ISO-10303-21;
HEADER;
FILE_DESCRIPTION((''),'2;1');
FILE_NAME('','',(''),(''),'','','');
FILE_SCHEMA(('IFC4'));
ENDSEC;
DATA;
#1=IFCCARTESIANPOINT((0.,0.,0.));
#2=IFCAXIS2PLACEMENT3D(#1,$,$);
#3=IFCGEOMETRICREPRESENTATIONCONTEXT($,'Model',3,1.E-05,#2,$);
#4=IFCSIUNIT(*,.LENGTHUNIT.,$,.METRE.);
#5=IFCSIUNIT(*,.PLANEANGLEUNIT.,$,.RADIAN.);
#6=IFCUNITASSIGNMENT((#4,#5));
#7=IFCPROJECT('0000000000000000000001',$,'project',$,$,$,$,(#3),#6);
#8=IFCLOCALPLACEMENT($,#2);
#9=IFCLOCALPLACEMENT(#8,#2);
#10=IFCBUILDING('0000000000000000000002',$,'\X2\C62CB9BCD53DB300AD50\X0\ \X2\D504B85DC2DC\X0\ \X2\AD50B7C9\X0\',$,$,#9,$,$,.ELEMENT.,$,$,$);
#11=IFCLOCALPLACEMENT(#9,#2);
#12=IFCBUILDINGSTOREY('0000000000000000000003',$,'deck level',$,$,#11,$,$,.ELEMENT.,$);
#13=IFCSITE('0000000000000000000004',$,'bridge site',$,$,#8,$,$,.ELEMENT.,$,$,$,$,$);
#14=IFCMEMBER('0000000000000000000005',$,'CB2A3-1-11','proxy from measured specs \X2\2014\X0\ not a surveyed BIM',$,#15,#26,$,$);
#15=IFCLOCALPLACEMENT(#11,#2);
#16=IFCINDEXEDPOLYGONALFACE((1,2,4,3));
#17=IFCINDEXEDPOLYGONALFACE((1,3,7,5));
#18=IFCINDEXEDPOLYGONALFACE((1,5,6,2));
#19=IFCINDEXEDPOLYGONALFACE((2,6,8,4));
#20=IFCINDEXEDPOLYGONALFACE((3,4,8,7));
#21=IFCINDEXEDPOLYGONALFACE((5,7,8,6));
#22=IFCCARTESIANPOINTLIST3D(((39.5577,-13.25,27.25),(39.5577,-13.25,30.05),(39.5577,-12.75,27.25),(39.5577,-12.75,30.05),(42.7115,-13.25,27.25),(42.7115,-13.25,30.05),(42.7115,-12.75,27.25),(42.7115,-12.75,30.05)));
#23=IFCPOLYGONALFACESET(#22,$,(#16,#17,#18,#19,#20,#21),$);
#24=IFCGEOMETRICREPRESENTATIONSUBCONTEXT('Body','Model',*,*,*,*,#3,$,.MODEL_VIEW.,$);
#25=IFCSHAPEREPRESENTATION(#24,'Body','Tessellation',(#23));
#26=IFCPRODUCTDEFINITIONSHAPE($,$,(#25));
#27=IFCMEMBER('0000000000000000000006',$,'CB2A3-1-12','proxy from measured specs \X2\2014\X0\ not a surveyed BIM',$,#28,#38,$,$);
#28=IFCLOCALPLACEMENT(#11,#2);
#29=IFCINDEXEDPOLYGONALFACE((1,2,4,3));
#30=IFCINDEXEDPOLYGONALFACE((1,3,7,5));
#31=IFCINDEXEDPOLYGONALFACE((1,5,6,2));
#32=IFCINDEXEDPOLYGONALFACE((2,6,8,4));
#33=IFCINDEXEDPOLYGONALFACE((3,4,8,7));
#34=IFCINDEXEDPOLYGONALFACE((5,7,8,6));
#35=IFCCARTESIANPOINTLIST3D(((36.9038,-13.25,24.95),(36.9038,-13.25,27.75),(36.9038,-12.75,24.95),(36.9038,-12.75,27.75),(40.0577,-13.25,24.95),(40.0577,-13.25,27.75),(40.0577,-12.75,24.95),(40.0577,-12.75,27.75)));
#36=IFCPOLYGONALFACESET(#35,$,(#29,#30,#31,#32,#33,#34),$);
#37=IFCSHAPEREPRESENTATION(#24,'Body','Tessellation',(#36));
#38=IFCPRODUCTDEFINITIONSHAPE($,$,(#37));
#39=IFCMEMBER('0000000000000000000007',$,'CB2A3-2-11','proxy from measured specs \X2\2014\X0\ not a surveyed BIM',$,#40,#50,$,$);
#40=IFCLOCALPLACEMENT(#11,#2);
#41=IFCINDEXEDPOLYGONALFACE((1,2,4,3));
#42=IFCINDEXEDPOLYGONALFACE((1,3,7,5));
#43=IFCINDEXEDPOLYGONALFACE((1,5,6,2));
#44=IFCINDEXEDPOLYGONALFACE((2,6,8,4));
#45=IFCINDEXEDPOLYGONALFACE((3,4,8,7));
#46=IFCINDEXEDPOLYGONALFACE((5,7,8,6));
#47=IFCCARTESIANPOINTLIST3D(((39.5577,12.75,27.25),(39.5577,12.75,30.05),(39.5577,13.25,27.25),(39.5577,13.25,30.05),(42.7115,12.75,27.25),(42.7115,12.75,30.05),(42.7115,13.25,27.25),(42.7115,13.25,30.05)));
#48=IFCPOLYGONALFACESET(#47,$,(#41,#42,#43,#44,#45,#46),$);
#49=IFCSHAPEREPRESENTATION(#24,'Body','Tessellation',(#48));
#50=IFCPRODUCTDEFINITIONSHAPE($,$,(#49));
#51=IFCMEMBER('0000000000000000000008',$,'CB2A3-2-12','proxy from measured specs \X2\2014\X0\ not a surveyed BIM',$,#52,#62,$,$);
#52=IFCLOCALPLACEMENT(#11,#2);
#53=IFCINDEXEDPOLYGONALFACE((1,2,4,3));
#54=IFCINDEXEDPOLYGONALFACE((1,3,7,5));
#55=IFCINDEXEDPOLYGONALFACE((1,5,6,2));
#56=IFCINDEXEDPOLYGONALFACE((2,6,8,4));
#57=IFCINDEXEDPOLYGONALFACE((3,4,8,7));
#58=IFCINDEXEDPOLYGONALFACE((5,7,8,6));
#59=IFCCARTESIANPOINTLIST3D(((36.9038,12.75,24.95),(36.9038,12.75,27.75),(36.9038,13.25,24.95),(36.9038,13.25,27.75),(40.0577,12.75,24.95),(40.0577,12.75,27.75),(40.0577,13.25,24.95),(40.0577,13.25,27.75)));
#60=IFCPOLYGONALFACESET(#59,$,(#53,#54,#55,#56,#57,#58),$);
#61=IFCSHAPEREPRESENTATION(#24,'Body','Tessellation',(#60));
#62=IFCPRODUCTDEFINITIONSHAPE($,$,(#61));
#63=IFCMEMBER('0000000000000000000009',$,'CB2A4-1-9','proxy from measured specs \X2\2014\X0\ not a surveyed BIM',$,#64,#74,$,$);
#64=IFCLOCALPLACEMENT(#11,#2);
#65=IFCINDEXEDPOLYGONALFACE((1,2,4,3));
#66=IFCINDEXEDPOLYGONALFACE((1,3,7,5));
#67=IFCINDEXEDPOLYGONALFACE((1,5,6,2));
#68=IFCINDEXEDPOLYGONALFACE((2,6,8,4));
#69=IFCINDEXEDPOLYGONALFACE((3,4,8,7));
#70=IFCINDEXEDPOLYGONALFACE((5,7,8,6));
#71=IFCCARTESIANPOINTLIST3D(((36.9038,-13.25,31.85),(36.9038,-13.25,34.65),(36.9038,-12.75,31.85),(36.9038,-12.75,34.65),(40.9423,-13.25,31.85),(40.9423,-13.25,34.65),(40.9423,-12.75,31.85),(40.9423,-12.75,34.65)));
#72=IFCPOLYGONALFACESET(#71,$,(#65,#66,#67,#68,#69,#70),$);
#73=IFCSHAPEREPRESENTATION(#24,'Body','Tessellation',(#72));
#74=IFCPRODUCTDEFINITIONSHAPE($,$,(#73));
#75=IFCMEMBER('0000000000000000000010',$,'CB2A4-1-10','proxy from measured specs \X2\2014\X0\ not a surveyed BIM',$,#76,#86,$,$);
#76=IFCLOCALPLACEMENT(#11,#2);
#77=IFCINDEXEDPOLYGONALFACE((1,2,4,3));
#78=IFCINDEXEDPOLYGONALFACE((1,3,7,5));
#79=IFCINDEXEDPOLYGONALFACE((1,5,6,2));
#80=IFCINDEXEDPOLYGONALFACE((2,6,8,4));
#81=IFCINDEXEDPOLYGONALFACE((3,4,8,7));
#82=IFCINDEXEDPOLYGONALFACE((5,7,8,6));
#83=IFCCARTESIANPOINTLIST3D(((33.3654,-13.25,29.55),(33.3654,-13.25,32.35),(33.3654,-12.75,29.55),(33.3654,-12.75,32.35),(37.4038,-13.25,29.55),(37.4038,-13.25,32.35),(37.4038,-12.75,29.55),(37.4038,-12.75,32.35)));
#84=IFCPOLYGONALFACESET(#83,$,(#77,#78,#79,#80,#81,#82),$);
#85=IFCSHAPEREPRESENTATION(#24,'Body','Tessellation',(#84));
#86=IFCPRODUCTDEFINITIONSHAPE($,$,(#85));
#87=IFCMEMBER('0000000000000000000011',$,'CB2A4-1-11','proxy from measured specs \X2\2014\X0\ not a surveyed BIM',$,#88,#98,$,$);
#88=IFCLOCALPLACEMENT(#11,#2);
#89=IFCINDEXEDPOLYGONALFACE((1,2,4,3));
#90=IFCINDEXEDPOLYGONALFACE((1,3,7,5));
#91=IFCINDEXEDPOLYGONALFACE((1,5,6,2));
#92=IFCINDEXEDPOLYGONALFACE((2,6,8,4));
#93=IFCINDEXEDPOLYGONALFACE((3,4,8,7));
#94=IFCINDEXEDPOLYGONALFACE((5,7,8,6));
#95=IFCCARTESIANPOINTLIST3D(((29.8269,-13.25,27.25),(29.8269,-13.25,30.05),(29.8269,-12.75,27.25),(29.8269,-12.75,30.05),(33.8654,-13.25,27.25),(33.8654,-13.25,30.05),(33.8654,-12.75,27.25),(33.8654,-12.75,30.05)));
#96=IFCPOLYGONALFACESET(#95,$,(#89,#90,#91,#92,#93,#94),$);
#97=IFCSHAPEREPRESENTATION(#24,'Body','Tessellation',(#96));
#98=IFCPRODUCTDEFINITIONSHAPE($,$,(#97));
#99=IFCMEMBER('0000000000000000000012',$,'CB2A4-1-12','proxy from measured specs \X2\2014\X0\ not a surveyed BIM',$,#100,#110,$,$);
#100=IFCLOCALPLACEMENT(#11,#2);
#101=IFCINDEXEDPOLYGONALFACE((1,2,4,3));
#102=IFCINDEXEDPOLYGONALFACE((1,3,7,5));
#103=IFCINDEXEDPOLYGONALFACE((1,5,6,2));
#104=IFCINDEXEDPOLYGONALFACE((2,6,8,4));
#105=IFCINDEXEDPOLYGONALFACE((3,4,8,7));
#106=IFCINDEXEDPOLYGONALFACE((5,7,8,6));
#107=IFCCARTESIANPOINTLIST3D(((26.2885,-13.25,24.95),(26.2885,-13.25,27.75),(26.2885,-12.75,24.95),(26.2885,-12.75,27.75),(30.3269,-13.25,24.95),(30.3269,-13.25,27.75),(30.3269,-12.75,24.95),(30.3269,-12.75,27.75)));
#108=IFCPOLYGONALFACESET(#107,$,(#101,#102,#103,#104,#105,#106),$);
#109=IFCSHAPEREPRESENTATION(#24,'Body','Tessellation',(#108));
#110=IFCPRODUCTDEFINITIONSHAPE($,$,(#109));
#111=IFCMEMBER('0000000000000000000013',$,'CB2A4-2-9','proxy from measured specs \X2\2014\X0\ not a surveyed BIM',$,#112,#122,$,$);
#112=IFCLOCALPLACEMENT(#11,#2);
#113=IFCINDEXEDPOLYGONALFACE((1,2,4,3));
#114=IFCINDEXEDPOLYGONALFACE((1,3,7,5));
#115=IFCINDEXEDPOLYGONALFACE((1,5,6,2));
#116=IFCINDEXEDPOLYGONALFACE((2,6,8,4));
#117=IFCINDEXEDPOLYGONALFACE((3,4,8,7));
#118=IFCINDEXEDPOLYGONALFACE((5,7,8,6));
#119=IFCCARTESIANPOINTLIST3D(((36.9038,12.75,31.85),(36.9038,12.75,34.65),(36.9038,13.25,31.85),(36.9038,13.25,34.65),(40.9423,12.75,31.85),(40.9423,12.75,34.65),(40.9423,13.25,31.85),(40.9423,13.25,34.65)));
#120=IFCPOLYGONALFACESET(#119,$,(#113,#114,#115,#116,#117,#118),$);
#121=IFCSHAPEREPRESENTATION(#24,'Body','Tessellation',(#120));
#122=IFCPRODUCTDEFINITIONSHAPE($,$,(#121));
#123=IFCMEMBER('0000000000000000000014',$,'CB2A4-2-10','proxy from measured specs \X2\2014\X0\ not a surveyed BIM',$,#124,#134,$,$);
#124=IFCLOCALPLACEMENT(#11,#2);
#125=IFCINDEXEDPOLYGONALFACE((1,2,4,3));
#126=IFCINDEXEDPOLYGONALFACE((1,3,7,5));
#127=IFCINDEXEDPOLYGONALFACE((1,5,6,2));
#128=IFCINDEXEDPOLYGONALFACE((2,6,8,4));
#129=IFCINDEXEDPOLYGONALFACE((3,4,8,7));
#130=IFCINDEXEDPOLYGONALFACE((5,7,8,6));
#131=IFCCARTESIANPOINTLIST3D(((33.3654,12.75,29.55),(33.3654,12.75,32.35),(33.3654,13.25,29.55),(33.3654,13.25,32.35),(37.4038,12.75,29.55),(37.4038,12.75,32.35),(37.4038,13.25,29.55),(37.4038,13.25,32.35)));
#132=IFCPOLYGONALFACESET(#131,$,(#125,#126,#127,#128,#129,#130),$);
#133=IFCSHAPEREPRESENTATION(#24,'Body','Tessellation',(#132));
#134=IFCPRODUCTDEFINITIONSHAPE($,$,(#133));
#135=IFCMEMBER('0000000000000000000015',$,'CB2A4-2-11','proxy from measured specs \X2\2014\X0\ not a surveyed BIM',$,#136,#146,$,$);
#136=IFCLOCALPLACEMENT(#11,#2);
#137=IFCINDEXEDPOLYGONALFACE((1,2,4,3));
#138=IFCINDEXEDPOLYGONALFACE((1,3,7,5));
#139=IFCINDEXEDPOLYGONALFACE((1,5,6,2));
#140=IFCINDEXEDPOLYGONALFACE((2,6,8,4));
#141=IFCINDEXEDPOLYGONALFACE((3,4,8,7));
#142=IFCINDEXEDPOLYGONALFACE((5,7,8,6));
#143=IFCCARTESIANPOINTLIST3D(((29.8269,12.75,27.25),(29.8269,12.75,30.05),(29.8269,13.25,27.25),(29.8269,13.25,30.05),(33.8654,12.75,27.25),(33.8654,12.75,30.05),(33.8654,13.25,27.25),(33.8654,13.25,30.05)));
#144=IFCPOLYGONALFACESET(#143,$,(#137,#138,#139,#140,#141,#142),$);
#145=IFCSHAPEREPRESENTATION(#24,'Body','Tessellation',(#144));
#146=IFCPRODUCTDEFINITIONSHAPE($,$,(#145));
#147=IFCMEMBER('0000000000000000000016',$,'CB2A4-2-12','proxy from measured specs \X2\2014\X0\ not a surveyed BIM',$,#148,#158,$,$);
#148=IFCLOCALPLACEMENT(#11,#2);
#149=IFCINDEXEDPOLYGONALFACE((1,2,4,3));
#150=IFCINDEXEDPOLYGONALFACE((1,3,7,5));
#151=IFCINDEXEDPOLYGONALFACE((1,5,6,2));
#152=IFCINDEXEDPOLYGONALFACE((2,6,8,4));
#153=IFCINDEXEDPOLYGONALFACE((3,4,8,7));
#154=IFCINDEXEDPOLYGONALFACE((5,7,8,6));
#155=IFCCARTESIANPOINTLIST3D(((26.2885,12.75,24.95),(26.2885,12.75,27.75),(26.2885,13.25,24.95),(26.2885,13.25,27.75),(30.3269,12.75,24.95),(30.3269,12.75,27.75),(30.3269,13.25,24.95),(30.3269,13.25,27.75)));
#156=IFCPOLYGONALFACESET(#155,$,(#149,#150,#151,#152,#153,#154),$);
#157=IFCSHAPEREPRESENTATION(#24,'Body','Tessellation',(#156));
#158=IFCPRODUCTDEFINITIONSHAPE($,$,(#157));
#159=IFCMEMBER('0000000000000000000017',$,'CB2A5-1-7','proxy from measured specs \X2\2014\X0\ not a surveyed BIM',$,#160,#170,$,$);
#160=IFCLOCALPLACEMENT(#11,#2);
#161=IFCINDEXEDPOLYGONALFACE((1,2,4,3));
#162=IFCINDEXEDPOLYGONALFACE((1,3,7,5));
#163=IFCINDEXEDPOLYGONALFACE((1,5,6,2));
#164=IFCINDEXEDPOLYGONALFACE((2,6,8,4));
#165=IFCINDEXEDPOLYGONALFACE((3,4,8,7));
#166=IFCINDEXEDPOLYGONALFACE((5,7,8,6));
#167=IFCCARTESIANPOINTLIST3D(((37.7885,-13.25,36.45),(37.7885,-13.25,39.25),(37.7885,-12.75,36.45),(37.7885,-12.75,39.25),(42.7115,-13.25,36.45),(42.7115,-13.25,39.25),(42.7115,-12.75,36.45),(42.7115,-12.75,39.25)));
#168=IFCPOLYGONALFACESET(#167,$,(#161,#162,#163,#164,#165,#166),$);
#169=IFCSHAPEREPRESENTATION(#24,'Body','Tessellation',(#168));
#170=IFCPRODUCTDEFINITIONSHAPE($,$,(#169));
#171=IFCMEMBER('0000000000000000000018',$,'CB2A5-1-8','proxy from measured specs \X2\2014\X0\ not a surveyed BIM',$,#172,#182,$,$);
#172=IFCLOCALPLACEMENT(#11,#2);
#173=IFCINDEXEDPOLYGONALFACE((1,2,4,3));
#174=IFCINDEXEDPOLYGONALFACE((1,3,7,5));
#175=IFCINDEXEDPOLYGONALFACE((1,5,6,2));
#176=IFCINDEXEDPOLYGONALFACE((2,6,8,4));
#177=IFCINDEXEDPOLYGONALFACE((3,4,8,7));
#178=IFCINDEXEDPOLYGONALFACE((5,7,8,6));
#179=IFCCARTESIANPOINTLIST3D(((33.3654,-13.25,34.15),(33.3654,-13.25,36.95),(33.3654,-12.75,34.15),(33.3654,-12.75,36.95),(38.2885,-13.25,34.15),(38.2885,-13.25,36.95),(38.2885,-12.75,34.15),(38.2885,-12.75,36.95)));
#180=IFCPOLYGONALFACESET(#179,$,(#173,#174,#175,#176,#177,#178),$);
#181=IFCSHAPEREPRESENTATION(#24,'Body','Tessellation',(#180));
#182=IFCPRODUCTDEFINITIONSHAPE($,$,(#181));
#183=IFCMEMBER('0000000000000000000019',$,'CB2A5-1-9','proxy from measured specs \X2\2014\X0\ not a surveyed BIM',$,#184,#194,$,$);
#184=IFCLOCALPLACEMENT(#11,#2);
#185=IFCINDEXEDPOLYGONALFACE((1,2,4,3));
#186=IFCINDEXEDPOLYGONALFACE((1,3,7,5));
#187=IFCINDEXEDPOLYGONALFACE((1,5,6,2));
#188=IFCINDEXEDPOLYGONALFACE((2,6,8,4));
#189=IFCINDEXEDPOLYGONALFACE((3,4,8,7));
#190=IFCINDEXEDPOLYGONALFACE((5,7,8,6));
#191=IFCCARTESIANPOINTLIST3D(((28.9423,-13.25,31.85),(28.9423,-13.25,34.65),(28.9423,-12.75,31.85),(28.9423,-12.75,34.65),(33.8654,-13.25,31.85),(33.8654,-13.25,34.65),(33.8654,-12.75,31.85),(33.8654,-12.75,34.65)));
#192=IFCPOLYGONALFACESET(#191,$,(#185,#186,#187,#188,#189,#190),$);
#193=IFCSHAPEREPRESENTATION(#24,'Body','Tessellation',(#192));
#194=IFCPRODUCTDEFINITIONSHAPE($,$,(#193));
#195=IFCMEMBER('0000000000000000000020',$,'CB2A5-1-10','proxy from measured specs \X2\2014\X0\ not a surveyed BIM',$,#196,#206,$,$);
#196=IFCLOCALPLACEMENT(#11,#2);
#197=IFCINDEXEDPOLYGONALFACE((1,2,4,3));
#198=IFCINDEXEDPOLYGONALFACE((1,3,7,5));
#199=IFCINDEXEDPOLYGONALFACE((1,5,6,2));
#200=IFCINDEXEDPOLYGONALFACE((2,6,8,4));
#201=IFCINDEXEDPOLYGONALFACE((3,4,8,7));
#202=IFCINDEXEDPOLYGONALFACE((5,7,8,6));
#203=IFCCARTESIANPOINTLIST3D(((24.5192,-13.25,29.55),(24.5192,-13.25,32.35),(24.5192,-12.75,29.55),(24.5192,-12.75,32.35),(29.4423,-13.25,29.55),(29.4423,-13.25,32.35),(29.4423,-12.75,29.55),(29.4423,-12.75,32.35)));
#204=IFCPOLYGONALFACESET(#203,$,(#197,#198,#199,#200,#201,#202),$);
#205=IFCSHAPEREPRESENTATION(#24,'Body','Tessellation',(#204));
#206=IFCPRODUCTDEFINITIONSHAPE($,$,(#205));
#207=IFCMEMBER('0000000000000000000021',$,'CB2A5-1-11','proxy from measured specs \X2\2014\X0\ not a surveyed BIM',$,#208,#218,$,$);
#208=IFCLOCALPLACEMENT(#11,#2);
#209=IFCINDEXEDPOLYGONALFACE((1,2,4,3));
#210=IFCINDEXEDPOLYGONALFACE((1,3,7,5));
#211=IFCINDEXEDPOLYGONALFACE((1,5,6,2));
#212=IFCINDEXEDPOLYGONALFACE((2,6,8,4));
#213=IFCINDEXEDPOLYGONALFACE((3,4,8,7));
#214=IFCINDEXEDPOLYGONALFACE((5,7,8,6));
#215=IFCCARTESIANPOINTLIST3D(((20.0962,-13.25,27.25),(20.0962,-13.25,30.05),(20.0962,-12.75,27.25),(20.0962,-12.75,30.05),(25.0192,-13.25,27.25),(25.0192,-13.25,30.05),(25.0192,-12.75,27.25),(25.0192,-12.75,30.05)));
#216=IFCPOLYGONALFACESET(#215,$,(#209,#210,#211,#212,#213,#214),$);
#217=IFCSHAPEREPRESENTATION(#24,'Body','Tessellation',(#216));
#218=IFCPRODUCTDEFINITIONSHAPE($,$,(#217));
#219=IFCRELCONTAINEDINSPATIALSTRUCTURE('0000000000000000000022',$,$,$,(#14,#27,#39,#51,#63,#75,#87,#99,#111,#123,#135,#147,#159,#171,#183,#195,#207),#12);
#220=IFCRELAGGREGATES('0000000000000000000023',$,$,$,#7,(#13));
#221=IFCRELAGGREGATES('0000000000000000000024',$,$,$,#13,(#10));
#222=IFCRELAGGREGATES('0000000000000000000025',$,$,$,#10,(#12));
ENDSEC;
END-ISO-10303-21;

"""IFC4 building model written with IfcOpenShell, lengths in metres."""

from ifc_helpers import new_model, si_unit, frame, origin, origin_2d, place, context, subcontext, project, spatial, rectangle, extrude, element, save


model = new_model("IFC4")

# Units and contexts
model_context = context("Model", 3, precision=1e-05, world=origin())
body_context = subcontext(model_context, "Body", "Model", "MODEL_VIEW")
ifc_project = project(units=[si_unit("LENGTHUNIT", "METRE"), si_unit("PLANEANGLEUNIT", "RADIAN")], contexts=[model_context])

# Site, building, storey
site_placement = place(None, origin())
site = spatial("IfcSite", under=ifc_project, at=site_placement, Name="bridge site", CompositionType="ELEMENT")
building_placement = place(site_placement, origin())
building = spatial("IfcBuilding", under=site, at=building_placement, Name="올림픽대교 프록시 교량", CompositionType="ELEMENT")
storey_placement = place(building_placement, origin())
storey = spatial("IfcBuildingStorey", under=building, at=storey_placement, Name="deck level", CompositionType="ELEMENT")

# Members
member_1_placement = place(storey_placement, frame((41.1346, -13.0, 27.25)))
element("IfcMember", 1, at=member_1_placement, inside=storey, Name="CB2A3-1-11", Description="proxy from measured specs — not a surveyed BIM", context=body_context, shape_type="SweptSolid", body=[
    extrude(rectangle(XDim=3.1538, YDim=0.5, at=origin_2d()), origin(), (0.0, 0.0, 1.0), 2.8),
])
member_2_placement = place(storey_placement, frame((38.4808, -13.0, 24.95)))
element("IfcMember", 2, at=member_2_placement, inside=storey, Name="CB2A3-1-12", Description="proxy from measured specs — not a surveyed BIM", context=body_context, shape_type="SweptSolid", body=[
    extrude(rectangle(XDim=3.1538, YDim=0.5, at=origin_2d()), origin(), (0.0, 0.0, 1.0), 2.8),
])
member_3_placement = place(storey_placement, frame((41.1346, 13.0, 27.25)))
element("IfcMember", 3, at=member_3_placement, inside=storey, Name="CB2A3-2-11", Description="proxy from measured specs — not a surveyed BIM", context=body_context, shape_type="SweptSolid", body=[
    extrude(rectangle(XDim=3.1538, YDim=0.5, at=origin_2d()), origin(), (0.0, 0.0, 1.0), 2.8),
])
member_4_placement = place(storey_placement, frame((38.4808, 13.0, 24.95)))
element("IfcMember", 4, at=member_4_placement, inside=storey, Name="CB2A3-2-12", Description="proxy from measured specs — not a surveyed BIM", context=body_context, shape_type="SweptSolid", body=[
    extrude(rectangle(XDim=3.1538, YDim=0.5, at=origin_2d()), origin(), (0.0, 0.0, 1.0), 2.8),
])
member_5_placement = place(storey_placement, frame((38.9231, -13.0, 31.85)))
element("IfcMember", 5, at=member_5_placement, inside=storey, Name="CB2A4-1-9", Description="proxy from measured specs — not a surveyed BIM", context=body_context, shape_type="SweptSolid", body=[
    extrude(rectangle(XDim=4.0385, YDim=0.5, at=origin_2d()), origin(), (0.0, 0.0, 1.0), 2.8),
])
for number, where, name in (
    (6, (35.3846, -13.0, 29.55), "CB2A4-1-10"),
    (7, (31.8462, -13.0, 27.25), "CB2A4-1-11"),
):
    element("IfcMember", number, at=place(storey_placement, frame(where)), inside=storey, Name=name, Description="proxy from measured specs — not a surveyed BIM", context=body_context, shape_type="SweptSolid", body=[
        extrude(rectangle(XDim=4.0385, YDim=0.5, at=origin_2d()), origin(), (0.0, 0.0, 1.0), 2.8),
    ])
member_6_placement = place(storey_placement, frame((28.3077, -13.0, 24.95)))
element("IfcMember", 8, at=member_6_placement, inside=storey, Name="CB2A4-1-12", Description="proxy from measured specs — not a surveyed BIM", context=body_context, shape_type="SweptSolid", body=[
    extrude(rectangle(XDim=4.0385, YDim=0.5, at=origin_2d()), origin(), (0.0, 0.0, 1.0), 2.8),
])
member_7_placement = place(storey_placement, frame((38.9231, 13.0, 31.85)))
element("IfcMember", 9, at=member_7_placement, inside=storey, Name="CB2A4-2-9", Description="proxy from measured specs — not a surveyed BIM", context=body_context, shape_type="SweptSolid", body=[
    extrude(rectangle(XDim=4.0385, YDim=0.5, at=origin_2d()), origin(), (0.0, 0.0, 1.0), 2.8),
])
for number, where, name in (
    (10, (35.3846, 13.0, 29.55), "CB2A4-2-10"),
    (11, (31.8462, 13.0, 27.25), "CB2A4-2-11"),
):
    element("IfcMember", number, at=place(storey_placement, frame(where)), inside=storey, Name=name, Description="proxy from measured specs — not a surveyed BIM", context=body_context, shape_type="SweptSolid", body=[
        extrude(rectangle(XDim=4.0385, YDim=0.5, at=origin_2d()), origin(), (0.0, 0.0, 1.0), 2.8),
    ])
member_8_placement = place(storey_placement, frame((28.3077, 13.0, 24.95)))
element("IfcMember", 12, at=member_8_placement, inside=storey, Name="CB2A4-2-12", Description="proxy from measured specs — not a surveyed BIM", context=body_context, shape_type="SweptSolid", body=[
    extrude(rectangle(XDim=4.0385, YDim=0.5, at=origin_2d()), origin(), (0.0, 0.0, 1.0), 2.8),
])
member_9_placement = place(storey_placement, frame((40.25, -13.0, 36.45)))
element("IfcMember", 13, at=member_9_placement, inside=storey, Name="CB2A5-1-7", Description="proxy from measured specs — not a surveyed BIM", context=body_context, shape_type="SweptSolid", body=[
    extrude(rectangle(XDim=4.9231, YDim=0.5, at=origin_2d()), origin(), (0.0, 0.0, 1.0), 2.8),
])
member_10_placement = place(storey_placement, frame((35.8269, -13.0, 34.15)))
element("IfcMember", 14, at=member_10_placement, inside=storey, Name="CB2A5-1-8", Description="proxy from measured specs — not a surveyed BIM", context=body_context, shape_type="SweptSolid", body=[
    extrude(rectangle(XDim=4.9231, YDim=0.5, at=origin_2d()), origin(), (0.0, 0.0, 1.0), 2.8),
])
member_11_placement = place(storey_placement, frame((31.4038, -13.0, 31.85)))
element("IfcMember", 15, at=member_11_placement, inside=storey, Name="CB2A5-1-9", Description="proxy from measured specs — not a surveyed BIM", context=body_context, shape_type="SweptSolid", body=[
    extrude(rectangle(XDim=4.9231, YDim=0.5, at=origin_2d()), origin(), (0.0, 0.0, 1.0), 2.8),
])
member_12_placement = place(storey_placement, frame((26.9808, -13.0, 29.55)))
element("IfcMember", 16, at=member_12_placement, inside=storey, Name="CB2A5-1-10", Description="proxy from measured specs — not a surveyed BIM", context=body_context, shape_type="SweptSolid", body=[
    extrude(rectangle(XDim=4.9231, YDim=0.5, at=origin_2d()), origin(), (0.0, 0.0, 1.0), 2.8),
])
member_13_placement = place(storey_placement, frame((22.5577, -13.0, 27.25)))
element("IfcMember", 17, at=member_13_placement, inside=storey, Name="CB2A5-1-11", Description="proxy from measured specs — not a surveyed BIM", context=body_context, shape_type="SweptSolid", body=[
    extrude(rectangle(XDim=4.9231, YDim=0.5, at=origin_2d()), origin(), (0.0, 0.0, 1.0), 2.8),
])

save(model, "model.ifc")
